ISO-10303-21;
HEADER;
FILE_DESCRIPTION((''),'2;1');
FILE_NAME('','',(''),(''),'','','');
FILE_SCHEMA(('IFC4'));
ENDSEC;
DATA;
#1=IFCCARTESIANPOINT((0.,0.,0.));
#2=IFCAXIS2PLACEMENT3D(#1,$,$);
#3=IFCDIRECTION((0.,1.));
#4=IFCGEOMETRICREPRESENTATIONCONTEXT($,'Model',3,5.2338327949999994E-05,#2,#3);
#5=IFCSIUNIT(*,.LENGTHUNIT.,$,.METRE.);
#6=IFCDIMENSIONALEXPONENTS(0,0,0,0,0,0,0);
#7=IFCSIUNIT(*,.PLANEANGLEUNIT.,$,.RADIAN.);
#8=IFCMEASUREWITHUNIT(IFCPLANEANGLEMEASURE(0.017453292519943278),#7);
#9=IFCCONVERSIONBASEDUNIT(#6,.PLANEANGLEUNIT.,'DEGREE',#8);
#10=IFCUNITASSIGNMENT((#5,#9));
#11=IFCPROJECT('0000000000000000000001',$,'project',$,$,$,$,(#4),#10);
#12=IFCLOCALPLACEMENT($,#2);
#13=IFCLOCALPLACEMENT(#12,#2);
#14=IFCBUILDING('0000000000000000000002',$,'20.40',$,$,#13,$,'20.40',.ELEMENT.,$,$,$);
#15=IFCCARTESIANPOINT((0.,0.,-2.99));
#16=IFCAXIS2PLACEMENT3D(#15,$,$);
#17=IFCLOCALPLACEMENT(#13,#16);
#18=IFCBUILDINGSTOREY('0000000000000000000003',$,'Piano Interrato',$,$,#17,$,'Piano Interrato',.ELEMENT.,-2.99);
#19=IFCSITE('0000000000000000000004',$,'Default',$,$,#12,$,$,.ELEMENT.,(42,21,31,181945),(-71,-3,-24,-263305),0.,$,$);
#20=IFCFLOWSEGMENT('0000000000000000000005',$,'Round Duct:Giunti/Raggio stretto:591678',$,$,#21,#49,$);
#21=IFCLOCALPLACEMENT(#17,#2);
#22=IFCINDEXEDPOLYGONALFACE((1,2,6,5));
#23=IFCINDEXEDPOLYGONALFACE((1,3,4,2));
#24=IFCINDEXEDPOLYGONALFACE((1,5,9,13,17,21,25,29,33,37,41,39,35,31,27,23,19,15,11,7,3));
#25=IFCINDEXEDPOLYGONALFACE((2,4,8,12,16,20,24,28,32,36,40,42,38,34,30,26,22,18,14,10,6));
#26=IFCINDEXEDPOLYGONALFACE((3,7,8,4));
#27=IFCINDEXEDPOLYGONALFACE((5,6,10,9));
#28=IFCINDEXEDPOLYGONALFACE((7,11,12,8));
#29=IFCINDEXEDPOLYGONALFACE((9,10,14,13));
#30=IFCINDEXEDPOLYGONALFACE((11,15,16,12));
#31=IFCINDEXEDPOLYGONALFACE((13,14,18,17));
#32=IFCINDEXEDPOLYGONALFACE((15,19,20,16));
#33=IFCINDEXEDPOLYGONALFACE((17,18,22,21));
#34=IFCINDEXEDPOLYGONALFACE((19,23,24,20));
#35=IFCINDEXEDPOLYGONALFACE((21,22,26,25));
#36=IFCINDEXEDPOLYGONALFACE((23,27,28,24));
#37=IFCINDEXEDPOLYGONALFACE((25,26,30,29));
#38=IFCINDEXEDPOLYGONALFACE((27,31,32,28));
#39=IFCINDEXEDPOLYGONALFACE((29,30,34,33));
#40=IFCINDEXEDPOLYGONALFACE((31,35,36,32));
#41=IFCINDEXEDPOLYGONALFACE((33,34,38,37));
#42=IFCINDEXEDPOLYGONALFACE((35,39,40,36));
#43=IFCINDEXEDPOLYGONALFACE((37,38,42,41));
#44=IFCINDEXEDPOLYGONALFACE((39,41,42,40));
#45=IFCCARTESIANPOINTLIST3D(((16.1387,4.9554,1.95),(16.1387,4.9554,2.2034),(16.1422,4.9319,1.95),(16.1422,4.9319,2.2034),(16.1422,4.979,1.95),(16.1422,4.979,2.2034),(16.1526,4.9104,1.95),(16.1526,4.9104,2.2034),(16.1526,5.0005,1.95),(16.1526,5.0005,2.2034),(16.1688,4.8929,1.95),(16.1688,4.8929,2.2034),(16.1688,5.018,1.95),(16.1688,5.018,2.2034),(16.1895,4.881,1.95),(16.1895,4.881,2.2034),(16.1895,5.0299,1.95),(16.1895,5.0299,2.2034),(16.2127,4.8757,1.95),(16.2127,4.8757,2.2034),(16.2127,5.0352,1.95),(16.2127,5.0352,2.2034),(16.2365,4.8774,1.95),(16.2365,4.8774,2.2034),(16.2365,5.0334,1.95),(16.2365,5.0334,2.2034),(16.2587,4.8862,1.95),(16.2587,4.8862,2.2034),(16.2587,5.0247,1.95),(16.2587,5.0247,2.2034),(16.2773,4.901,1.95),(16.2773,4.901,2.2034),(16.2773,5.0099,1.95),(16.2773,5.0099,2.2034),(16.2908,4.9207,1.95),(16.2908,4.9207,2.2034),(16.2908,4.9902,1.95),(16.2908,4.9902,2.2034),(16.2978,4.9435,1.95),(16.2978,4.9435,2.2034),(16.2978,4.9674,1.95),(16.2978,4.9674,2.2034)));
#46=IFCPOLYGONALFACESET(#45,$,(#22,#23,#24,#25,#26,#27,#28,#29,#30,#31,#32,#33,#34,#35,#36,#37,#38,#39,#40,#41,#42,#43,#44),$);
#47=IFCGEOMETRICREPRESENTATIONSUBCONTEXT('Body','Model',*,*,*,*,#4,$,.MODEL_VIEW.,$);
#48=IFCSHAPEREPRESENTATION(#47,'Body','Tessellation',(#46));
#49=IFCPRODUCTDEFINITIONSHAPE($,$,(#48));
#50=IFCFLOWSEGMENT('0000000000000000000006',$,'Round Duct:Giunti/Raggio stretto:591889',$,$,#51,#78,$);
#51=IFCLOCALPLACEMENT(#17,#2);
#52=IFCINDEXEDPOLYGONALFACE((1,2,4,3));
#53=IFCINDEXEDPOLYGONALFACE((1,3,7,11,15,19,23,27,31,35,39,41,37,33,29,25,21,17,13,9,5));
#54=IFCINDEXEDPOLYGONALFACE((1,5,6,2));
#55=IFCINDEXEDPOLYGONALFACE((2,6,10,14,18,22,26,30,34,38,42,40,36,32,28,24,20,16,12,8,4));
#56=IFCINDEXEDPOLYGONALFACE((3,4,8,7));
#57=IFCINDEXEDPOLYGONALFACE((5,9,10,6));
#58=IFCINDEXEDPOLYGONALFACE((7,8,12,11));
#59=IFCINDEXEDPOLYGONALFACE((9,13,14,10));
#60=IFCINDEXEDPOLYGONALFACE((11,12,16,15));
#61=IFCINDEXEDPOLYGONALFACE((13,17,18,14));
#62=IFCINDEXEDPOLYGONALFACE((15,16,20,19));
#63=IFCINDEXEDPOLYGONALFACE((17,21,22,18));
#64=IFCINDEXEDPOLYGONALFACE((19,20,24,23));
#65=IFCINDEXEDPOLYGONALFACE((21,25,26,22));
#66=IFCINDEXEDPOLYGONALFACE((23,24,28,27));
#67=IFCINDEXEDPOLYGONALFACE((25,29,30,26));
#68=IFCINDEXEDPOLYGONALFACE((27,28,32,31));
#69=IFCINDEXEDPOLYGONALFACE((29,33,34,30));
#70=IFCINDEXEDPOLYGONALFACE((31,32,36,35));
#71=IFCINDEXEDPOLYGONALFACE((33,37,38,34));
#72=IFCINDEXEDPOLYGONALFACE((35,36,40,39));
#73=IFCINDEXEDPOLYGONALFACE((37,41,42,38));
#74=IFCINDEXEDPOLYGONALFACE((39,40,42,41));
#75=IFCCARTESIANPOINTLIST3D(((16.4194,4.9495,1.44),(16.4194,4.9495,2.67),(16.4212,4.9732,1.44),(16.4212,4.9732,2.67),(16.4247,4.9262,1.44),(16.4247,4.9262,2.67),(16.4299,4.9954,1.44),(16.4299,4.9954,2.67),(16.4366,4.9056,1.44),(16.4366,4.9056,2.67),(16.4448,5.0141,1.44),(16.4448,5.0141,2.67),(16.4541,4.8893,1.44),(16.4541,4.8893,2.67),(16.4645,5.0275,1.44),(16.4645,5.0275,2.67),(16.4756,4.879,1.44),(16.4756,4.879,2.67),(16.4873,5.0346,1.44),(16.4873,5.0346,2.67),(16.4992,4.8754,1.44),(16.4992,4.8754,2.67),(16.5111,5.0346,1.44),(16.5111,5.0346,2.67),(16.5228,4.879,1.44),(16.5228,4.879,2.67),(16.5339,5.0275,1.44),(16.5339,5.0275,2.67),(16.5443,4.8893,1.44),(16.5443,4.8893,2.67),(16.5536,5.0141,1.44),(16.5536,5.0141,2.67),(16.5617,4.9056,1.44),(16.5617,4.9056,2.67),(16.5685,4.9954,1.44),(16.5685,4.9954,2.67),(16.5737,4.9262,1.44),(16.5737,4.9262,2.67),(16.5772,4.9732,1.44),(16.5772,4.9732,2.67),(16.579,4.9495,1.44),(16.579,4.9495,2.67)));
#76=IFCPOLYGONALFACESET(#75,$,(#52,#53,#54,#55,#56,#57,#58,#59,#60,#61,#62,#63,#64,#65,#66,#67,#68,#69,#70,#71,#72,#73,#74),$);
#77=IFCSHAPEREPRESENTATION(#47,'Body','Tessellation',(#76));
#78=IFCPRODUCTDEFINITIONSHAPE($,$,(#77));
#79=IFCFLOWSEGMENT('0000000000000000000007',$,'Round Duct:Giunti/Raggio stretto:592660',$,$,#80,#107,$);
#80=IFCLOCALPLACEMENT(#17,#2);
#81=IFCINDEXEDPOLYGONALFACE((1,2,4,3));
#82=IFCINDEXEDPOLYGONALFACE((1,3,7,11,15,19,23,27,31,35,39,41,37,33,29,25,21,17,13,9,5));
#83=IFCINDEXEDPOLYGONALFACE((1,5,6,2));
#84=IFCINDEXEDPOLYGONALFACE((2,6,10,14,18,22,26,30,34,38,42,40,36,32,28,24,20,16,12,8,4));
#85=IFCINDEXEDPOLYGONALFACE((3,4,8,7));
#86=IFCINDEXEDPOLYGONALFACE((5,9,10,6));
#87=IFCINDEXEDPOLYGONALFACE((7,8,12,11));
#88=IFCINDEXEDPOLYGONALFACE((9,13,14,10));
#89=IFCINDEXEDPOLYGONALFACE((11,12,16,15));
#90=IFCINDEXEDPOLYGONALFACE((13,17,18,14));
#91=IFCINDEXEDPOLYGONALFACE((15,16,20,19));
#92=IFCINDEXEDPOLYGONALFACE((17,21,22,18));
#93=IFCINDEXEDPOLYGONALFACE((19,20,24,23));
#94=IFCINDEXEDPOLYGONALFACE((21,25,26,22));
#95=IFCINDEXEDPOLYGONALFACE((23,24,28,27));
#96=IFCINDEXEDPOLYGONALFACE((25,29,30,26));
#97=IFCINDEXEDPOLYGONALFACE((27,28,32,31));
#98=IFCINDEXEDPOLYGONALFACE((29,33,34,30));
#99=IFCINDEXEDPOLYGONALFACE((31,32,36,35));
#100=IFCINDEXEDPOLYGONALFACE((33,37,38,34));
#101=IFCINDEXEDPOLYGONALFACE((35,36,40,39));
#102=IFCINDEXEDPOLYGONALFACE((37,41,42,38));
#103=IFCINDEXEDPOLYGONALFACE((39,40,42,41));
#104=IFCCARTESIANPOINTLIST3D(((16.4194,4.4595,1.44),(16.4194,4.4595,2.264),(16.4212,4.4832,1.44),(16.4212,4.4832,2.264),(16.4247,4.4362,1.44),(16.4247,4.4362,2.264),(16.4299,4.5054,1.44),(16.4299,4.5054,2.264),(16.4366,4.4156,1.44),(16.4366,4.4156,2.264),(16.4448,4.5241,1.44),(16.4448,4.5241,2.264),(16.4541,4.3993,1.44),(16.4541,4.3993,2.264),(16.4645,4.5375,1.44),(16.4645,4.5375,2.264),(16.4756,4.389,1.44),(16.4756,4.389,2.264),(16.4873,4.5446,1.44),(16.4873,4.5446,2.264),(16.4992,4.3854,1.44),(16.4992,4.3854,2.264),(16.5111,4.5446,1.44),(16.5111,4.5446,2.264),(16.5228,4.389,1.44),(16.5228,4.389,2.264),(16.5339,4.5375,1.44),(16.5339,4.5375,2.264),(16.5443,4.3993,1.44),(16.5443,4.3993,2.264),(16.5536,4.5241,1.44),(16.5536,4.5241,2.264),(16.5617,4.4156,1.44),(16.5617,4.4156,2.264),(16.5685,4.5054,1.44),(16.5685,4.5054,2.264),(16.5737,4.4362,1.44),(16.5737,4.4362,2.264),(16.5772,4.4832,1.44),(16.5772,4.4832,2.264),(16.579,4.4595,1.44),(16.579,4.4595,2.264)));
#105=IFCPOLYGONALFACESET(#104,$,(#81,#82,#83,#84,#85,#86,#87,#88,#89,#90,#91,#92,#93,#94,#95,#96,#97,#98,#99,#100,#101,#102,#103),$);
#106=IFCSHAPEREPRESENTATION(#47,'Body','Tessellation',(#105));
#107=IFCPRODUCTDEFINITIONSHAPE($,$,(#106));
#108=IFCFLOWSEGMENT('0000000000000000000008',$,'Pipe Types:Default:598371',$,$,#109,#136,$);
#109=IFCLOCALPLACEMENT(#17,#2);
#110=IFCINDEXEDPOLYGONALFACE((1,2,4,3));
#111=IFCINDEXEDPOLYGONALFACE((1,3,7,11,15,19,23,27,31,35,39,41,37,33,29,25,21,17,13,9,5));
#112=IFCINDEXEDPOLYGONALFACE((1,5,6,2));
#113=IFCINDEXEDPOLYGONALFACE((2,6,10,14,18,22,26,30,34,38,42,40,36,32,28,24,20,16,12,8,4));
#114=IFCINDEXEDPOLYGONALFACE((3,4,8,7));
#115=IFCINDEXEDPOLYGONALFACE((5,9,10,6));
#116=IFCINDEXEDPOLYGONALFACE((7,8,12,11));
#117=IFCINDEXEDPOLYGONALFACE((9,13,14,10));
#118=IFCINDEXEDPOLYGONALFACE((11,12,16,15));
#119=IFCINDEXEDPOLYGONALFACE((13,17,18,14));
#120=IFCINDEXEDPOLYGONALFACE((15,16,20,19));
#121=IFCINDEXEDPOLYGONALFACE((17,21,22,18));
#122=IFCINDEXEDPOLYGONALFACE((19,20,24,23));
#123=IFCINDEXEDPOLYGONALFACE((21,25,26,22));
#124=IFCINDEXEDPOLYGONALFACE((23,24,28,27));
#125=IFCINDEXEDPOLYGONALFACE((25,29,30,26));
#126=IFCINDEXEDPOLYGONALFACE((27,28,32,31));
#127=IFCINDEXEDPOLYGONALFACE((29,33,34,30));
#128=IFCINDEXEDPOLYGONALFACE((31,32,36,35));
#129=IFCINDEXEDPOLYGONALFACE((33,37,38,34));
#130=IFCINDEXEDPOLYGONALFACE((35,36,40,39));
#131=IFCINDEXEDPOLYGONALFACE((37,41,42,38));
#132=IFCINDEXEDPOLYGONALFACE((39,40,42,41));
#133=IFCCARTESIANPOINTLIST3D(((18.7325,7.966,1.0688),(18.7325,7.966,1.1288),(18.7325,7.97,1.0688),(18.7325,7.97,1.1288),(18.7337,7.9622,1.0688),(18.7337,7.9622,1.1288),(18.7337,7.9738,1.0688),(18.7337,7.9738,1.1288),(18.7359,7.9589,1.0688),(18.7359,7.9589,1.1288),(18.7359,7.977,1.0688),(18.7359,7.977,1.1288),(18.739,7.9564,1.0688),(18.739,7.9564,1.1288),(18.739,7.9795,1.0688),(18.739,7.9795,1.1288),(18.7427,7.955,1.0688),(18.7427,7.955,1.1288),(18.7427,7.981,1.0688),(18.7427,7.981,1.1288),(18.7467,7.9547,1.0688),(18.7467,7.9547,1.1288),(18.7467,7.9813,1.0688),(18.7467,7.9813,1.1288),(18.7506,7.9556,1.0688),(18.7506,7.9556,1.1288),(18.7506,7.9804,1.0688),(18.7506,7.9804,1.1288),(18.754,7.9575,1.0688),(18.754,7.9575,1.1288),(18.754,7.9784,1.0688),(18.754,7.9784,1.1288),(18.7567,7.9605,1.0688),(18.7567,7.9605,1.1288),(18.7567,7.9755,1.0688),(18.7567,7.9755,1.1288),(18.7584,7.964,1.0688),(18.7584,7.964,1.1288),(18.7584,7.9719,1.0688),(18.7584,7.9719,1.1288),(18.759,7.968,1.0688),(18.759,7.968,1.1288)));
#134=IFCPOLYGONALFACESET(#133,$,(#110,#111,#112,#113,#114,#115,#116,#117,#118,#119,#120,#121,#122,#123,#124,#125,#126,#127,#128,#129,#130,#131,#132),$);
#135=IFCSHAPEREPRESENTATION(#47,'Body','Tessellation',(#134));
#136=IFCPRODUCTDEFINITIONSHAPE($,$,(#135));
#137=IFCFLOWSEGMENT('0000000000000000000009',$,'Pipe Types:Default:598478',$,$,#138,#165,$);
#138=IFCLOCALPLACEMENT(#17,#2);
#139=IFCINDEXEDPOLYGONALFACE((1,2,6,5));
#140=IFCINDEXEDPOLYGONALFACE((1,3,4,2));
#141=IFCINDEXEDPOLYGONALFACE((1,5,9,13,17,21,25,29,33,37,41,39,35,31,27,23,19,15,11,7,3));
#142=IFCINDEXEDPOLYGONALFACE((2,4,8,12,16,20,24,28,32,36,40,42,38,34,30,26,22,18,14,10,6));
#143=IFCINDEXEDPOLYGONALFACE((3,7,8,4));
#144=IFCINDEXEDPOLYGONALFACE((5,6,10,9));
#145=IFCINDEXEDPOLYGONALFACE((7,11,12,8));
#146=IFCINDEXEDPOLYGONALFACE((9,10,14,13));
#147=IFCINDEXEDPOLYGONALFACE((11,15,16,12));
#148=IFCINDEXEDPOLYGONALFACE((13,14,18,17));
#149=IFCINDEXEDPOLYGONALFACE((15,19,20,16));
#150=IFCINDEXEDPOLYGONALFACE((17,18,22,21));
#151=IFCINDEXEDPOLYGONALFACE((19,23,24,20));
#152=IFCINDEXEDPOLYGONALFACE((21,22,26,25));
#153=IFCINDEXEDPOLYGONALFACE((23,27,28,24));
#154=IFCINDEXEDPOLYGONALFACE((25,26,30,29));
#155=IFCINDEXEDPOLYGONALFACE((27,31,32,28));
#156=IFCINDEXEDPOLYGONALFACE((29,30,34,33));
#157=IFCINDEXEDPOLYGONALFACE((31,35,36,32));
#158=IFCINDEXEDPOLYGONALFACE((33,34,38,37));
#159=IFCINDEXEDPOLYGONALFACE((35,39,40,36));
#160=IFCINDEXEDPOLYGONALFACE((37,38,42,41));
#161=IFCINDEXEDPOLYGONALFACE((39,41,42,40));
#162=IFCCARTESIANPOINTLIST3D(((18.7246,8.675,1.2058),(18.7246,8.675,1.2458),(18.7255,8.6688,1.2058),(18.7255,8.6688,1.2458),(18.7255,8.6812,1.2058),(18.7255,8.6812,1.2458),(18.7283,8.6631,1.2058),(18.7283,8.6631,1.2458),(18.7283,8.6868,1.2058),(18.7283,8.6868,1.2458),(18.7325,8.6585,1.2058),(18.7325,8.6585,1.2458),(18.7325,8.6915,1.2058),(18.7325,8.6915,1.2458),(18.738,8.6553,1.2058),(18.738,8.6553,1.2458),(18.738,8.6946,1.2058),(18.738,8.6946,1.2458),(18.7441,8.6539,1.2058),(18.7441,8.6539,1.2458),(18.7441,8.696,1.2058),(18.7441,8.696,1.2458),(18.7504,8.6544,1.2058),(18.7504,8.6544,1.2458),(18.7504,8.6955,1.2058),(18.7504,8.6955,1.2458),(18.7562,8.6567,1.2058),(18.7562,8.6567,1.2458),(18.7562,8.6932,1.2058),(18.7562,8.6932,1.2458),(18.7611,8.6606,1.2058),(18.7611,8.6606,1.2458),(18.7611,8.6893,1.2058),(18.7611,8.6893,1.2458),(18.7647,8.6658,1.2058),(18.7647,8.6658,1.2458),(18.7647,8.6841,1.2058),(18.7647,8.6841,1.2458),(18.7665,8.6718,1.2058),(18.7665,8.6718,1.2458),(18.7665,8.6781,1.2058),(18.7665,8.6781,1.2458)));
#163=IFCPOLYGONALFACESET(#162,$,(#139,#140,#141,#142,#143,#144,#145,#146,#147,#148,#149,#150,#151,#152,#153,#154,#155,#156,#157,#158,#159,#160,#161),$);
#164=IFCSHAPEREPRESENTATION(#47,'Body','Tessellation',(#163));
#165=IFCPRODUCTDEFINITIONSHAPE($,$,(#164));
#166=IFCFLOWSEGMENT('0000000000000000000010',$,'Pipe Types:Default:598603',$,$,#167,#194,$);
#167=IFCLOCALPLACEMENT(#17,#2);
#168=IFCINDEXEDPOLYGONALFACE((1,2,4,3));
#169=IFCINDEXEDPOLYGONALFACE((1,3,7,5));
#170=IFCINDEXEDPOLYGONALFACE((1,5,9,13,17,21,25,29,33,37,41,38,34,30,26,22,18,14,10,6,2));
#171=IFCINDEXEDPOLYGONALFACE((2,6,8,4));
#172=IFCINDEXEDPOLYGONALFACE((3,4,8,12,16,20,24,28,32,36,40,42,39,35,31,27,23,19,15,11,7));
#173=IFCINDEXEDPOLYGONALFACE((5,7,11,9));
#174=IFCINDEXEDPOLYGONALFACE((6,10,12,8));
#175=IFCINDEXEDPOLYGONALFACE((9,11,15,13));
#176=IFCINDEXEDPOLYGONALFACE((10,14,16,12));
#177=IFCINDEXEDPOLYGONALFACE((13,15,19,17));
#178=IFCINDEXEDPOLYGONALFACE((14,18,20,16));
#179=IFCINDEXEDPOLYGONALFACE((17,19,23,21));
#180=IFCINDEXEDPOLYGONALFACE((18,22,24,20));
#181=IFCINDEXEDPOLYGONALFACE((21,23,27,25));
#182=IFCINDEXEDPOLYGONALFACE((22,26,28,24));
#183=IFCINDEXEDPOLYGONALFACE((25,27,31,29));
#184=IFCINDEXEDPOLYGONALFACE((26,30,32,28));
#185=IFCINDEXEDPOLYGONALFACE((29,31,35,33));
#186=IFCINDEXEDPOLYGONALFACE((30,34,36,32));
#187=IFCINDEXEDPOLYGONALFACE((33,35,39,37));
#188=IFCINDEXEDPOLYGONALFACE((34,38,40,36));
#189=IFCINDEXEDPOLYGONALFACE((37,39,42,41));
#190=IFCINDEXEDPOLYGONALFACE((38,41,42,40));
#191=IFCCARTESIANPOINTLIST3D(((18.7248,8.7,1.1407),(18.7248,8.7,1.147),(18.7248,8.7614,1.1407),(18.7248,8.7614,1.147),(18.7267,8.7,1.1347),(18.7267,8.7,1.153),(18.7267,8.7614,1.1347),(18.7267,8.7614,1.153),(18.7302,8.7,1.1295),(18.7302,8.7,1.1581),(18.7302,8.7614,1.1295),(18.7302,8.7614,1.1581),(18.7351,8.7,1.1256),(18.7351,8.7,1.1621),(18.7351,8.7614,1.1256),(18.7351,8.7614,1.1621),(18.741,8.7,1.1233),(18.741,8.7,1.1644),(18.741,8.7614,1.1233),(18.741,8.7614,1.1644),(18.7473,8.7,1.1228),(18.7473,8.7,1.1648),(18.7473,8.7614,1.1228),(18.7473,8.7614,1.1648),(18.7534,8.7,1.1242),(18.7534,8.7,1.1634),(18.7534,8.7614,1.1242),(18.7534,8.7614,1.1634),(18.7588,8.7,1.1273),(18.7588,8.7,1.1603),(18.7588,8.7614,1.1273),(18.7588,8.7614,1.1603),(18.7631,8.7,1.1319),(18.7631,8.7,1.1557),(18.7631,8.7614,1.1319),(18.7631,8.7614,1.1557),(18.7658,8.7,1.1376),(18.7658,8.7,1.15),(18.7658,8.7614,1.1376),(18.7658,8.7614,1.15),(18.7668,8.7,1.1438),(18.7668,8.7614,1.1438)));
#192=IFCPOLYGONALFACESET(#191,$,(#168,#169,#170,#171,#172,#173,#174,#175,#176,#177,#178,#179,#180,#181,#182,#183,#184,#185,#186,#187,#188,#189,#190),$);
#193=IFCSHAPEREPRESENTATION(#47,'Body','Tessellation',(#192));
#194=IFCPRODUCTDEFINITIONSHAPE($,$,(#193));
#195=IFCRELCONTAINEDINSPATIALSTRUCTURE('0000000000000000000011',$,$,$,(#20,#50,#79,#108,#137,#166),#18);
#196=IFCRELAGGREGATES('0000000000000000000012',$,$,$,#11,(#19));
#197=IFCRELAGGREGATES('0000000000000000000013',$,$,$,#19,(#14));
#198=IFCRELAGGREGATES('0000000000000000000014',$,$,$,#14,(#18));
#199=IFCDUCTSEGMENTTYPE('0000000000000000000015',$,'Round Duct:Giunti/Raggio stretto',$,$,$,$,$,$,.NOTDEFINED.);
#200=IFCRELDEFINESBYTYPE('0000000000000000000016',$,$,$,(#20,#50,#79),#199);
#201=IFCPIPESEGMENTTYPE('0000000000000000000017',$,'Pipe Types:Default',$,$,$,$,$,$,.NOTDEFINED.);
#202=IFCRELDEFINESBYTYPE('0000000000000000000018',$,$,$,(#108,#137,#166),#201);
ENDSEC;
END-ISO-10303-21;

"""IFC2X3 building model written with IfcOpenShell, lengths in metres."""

from ifc_helpers import new_model, entity, si_unit, converted_unit, direction, frame, frame_2d, origin, origin_2d_with_axis, place, context, subcontext, project, spatial, circle, extrude, type_object, element, save


model = new_model("IFC2X3")

# Units and contexts
model_context = context("Model", 3, precision=5.2338327949999994e-05, world=origin(), true_north=direction((0.0, 1.0)))
body_context = subcontext(model_context, "Body", "Model", "MODEL_VIEW")
ifc_project = project(units=[si_unit("LENGTHUNIT", "METRE"), converted_unit("PLANEANGLEUNIT", "DEGREE", entity("IfcPlaneAngleMeasure", 0.017453292519943278), si_unit("PLANEANGLEUNIT", "RADIAN"), dimensions=[0, 0, 0, 0, 0, 0, 0])], contexts=[model_context])

# Site, building, storey
site_placement = place(None, origin())
site = spatial("IfcSite", under=ifc_project, at=site_placement, Name="Default", CompositionType="ELEMENT", RefLatitude=(42, 21, 31, 181945), RefLongitude=(-71, -3, -24, -263305), RefElevation=0.0)
building_placement = place(site_placement, origin())
building = spatial("IfcBuilding", under=site, at=building_placement, Name="20.40", LongName="20.40", CompositionType="ELEMENT")
storey_placement = place(building_placement, frame((0.0, 0.0, -2.99)))
storey = spatial("IfcBuildingStorey", under=building, at=storey_placement, Name="Piano Interrato", LongName="Piano Interrato", CompositionType="ELEMENT", Elevation=-2.99)

# Flow segments
duct_segment_type_1 = type_object("IfcDuctSegmentType", Name="Round Duct:Giunti/Raggio stretto", PredefinedType="NOTDEFINED")
flow_segment_1_placement = place(storey_placement, origin())
element("IfcFlowSegment", 1, at=flow_segment_1_placement, inside=storey, type_object=duct_segment_type_1, Name="Round Duct:Giunti/Raggio stretto:591678", context=body_context, shape_type="SweptSolid", body=[
    extrude(circle(Radius=0.08, at=frame_2d((0.0, 0.0), x_axis=(1.0, 0.0))), frame((16.2187, 4.9554, 1.95), z_axis=(0.0, 0.0, 1.0), x_axis=(-1.0, 0.0, 0.0)), (0.0, 0.0, 1.0), 0.2534),
])
flow_segment_2_placement = place(storey_placement, origin())
element("IfcFlowSegment", 2, at=flow_segment_2_placement, inside=storey, type_object=duct_segment_type_1, Name="Round Duct:Giunti/Raggio stretto:591889", context=body_context, shape_type="SweptSolid", body=[
    extrude(circle(Radius=0.08, at=origin_2d_with_axis()), frame((16.4992, 4.9554, 1.44), z_axis=(0.0, 0.0, 1.0), x_axis=(0.0, -1.0, 0.0)), (0.0, 0.0, 1.0), 1.23),
])
flow_segment_3_placement = place(storey_placement, origin())
element("IfcFlowSegment", 3, at=flow_segment_3_placement, inside=storey, type_object=duct_segment_type_1, Name="Round Duct:Giunti/Raggio stretto:592660", context=body_context, shape_type="SweptSolid", body=[
    extrude(circle(Radius=0.08, at=origin_2d_with_axis()), frame((16.4992, 4.4654, 1.44), z_axis=(0.0, 0.0, 1.0), x_axis=(0.0, -1.0, 0.0)), (0.0, 0.0, 1.0), 0.824),
])
pipe_segment_type_1 = type_object("IfcPipeSegmentType", Name="Pipe Types:Default", PredefinedType="NOTDEFINED")
flow_segment_4_placement = place(storey_placement, origin())
element("IfcFlowSegment", 4, at=flow_segment_4_placement, inside=storey, type_object=pipe_segment_type_1, Name="Pipe Types:Default:598371", context=body_context, shape_type="SweptSolid", body=[
    extrude(circle(Radius=0.0133, at=origin_2d_with_axis()), frame((18.7457, 7.968, 1.0688)), (0.0, 0.0, 1.0), 0.06),
])
flow_segment_5_placement = place(storey_placement, origin())
element("IfcFlowSegment", 5, at=flow_segment_5_placement, inside=storey, type_object=pipe_segment_type_1, Name="Pipe Types:Default:598478", context=body_context, shape_type="SweptSolid", body=[
    extrude(circle(Radius=0.0211, at=origin_2d_with_axis()), frame((18.7457, 8.675, 1.2058), z_axis=(0.0, 0.0, 1.0), x_axis=(-1.0, 0.0, 0.0)), (0.0, 0.0, 1.0), 0.04),
])
flow_segment_6_placement = place(storey_placement, origin())
element("IfcFlowSegment", 6, at=flow_segment_6_placement, inside=storey, type_object=pipe_segment_type_1, Name="Pipe Types:Default:598603", context=body_context, shape_type="SweptSolid", body=[
    extrude(circle(Radius=0.0211, at=origin_2d_with_axis()), frame((18.7457, 8.7, 1.1438), z_axis=(0.0, 1.0, 0.0), x_axis=(1.0, 0.0, 0.0)), (0.0, 0.0, 1.0), 0.0614),
])

save(model, "model.ifc")
